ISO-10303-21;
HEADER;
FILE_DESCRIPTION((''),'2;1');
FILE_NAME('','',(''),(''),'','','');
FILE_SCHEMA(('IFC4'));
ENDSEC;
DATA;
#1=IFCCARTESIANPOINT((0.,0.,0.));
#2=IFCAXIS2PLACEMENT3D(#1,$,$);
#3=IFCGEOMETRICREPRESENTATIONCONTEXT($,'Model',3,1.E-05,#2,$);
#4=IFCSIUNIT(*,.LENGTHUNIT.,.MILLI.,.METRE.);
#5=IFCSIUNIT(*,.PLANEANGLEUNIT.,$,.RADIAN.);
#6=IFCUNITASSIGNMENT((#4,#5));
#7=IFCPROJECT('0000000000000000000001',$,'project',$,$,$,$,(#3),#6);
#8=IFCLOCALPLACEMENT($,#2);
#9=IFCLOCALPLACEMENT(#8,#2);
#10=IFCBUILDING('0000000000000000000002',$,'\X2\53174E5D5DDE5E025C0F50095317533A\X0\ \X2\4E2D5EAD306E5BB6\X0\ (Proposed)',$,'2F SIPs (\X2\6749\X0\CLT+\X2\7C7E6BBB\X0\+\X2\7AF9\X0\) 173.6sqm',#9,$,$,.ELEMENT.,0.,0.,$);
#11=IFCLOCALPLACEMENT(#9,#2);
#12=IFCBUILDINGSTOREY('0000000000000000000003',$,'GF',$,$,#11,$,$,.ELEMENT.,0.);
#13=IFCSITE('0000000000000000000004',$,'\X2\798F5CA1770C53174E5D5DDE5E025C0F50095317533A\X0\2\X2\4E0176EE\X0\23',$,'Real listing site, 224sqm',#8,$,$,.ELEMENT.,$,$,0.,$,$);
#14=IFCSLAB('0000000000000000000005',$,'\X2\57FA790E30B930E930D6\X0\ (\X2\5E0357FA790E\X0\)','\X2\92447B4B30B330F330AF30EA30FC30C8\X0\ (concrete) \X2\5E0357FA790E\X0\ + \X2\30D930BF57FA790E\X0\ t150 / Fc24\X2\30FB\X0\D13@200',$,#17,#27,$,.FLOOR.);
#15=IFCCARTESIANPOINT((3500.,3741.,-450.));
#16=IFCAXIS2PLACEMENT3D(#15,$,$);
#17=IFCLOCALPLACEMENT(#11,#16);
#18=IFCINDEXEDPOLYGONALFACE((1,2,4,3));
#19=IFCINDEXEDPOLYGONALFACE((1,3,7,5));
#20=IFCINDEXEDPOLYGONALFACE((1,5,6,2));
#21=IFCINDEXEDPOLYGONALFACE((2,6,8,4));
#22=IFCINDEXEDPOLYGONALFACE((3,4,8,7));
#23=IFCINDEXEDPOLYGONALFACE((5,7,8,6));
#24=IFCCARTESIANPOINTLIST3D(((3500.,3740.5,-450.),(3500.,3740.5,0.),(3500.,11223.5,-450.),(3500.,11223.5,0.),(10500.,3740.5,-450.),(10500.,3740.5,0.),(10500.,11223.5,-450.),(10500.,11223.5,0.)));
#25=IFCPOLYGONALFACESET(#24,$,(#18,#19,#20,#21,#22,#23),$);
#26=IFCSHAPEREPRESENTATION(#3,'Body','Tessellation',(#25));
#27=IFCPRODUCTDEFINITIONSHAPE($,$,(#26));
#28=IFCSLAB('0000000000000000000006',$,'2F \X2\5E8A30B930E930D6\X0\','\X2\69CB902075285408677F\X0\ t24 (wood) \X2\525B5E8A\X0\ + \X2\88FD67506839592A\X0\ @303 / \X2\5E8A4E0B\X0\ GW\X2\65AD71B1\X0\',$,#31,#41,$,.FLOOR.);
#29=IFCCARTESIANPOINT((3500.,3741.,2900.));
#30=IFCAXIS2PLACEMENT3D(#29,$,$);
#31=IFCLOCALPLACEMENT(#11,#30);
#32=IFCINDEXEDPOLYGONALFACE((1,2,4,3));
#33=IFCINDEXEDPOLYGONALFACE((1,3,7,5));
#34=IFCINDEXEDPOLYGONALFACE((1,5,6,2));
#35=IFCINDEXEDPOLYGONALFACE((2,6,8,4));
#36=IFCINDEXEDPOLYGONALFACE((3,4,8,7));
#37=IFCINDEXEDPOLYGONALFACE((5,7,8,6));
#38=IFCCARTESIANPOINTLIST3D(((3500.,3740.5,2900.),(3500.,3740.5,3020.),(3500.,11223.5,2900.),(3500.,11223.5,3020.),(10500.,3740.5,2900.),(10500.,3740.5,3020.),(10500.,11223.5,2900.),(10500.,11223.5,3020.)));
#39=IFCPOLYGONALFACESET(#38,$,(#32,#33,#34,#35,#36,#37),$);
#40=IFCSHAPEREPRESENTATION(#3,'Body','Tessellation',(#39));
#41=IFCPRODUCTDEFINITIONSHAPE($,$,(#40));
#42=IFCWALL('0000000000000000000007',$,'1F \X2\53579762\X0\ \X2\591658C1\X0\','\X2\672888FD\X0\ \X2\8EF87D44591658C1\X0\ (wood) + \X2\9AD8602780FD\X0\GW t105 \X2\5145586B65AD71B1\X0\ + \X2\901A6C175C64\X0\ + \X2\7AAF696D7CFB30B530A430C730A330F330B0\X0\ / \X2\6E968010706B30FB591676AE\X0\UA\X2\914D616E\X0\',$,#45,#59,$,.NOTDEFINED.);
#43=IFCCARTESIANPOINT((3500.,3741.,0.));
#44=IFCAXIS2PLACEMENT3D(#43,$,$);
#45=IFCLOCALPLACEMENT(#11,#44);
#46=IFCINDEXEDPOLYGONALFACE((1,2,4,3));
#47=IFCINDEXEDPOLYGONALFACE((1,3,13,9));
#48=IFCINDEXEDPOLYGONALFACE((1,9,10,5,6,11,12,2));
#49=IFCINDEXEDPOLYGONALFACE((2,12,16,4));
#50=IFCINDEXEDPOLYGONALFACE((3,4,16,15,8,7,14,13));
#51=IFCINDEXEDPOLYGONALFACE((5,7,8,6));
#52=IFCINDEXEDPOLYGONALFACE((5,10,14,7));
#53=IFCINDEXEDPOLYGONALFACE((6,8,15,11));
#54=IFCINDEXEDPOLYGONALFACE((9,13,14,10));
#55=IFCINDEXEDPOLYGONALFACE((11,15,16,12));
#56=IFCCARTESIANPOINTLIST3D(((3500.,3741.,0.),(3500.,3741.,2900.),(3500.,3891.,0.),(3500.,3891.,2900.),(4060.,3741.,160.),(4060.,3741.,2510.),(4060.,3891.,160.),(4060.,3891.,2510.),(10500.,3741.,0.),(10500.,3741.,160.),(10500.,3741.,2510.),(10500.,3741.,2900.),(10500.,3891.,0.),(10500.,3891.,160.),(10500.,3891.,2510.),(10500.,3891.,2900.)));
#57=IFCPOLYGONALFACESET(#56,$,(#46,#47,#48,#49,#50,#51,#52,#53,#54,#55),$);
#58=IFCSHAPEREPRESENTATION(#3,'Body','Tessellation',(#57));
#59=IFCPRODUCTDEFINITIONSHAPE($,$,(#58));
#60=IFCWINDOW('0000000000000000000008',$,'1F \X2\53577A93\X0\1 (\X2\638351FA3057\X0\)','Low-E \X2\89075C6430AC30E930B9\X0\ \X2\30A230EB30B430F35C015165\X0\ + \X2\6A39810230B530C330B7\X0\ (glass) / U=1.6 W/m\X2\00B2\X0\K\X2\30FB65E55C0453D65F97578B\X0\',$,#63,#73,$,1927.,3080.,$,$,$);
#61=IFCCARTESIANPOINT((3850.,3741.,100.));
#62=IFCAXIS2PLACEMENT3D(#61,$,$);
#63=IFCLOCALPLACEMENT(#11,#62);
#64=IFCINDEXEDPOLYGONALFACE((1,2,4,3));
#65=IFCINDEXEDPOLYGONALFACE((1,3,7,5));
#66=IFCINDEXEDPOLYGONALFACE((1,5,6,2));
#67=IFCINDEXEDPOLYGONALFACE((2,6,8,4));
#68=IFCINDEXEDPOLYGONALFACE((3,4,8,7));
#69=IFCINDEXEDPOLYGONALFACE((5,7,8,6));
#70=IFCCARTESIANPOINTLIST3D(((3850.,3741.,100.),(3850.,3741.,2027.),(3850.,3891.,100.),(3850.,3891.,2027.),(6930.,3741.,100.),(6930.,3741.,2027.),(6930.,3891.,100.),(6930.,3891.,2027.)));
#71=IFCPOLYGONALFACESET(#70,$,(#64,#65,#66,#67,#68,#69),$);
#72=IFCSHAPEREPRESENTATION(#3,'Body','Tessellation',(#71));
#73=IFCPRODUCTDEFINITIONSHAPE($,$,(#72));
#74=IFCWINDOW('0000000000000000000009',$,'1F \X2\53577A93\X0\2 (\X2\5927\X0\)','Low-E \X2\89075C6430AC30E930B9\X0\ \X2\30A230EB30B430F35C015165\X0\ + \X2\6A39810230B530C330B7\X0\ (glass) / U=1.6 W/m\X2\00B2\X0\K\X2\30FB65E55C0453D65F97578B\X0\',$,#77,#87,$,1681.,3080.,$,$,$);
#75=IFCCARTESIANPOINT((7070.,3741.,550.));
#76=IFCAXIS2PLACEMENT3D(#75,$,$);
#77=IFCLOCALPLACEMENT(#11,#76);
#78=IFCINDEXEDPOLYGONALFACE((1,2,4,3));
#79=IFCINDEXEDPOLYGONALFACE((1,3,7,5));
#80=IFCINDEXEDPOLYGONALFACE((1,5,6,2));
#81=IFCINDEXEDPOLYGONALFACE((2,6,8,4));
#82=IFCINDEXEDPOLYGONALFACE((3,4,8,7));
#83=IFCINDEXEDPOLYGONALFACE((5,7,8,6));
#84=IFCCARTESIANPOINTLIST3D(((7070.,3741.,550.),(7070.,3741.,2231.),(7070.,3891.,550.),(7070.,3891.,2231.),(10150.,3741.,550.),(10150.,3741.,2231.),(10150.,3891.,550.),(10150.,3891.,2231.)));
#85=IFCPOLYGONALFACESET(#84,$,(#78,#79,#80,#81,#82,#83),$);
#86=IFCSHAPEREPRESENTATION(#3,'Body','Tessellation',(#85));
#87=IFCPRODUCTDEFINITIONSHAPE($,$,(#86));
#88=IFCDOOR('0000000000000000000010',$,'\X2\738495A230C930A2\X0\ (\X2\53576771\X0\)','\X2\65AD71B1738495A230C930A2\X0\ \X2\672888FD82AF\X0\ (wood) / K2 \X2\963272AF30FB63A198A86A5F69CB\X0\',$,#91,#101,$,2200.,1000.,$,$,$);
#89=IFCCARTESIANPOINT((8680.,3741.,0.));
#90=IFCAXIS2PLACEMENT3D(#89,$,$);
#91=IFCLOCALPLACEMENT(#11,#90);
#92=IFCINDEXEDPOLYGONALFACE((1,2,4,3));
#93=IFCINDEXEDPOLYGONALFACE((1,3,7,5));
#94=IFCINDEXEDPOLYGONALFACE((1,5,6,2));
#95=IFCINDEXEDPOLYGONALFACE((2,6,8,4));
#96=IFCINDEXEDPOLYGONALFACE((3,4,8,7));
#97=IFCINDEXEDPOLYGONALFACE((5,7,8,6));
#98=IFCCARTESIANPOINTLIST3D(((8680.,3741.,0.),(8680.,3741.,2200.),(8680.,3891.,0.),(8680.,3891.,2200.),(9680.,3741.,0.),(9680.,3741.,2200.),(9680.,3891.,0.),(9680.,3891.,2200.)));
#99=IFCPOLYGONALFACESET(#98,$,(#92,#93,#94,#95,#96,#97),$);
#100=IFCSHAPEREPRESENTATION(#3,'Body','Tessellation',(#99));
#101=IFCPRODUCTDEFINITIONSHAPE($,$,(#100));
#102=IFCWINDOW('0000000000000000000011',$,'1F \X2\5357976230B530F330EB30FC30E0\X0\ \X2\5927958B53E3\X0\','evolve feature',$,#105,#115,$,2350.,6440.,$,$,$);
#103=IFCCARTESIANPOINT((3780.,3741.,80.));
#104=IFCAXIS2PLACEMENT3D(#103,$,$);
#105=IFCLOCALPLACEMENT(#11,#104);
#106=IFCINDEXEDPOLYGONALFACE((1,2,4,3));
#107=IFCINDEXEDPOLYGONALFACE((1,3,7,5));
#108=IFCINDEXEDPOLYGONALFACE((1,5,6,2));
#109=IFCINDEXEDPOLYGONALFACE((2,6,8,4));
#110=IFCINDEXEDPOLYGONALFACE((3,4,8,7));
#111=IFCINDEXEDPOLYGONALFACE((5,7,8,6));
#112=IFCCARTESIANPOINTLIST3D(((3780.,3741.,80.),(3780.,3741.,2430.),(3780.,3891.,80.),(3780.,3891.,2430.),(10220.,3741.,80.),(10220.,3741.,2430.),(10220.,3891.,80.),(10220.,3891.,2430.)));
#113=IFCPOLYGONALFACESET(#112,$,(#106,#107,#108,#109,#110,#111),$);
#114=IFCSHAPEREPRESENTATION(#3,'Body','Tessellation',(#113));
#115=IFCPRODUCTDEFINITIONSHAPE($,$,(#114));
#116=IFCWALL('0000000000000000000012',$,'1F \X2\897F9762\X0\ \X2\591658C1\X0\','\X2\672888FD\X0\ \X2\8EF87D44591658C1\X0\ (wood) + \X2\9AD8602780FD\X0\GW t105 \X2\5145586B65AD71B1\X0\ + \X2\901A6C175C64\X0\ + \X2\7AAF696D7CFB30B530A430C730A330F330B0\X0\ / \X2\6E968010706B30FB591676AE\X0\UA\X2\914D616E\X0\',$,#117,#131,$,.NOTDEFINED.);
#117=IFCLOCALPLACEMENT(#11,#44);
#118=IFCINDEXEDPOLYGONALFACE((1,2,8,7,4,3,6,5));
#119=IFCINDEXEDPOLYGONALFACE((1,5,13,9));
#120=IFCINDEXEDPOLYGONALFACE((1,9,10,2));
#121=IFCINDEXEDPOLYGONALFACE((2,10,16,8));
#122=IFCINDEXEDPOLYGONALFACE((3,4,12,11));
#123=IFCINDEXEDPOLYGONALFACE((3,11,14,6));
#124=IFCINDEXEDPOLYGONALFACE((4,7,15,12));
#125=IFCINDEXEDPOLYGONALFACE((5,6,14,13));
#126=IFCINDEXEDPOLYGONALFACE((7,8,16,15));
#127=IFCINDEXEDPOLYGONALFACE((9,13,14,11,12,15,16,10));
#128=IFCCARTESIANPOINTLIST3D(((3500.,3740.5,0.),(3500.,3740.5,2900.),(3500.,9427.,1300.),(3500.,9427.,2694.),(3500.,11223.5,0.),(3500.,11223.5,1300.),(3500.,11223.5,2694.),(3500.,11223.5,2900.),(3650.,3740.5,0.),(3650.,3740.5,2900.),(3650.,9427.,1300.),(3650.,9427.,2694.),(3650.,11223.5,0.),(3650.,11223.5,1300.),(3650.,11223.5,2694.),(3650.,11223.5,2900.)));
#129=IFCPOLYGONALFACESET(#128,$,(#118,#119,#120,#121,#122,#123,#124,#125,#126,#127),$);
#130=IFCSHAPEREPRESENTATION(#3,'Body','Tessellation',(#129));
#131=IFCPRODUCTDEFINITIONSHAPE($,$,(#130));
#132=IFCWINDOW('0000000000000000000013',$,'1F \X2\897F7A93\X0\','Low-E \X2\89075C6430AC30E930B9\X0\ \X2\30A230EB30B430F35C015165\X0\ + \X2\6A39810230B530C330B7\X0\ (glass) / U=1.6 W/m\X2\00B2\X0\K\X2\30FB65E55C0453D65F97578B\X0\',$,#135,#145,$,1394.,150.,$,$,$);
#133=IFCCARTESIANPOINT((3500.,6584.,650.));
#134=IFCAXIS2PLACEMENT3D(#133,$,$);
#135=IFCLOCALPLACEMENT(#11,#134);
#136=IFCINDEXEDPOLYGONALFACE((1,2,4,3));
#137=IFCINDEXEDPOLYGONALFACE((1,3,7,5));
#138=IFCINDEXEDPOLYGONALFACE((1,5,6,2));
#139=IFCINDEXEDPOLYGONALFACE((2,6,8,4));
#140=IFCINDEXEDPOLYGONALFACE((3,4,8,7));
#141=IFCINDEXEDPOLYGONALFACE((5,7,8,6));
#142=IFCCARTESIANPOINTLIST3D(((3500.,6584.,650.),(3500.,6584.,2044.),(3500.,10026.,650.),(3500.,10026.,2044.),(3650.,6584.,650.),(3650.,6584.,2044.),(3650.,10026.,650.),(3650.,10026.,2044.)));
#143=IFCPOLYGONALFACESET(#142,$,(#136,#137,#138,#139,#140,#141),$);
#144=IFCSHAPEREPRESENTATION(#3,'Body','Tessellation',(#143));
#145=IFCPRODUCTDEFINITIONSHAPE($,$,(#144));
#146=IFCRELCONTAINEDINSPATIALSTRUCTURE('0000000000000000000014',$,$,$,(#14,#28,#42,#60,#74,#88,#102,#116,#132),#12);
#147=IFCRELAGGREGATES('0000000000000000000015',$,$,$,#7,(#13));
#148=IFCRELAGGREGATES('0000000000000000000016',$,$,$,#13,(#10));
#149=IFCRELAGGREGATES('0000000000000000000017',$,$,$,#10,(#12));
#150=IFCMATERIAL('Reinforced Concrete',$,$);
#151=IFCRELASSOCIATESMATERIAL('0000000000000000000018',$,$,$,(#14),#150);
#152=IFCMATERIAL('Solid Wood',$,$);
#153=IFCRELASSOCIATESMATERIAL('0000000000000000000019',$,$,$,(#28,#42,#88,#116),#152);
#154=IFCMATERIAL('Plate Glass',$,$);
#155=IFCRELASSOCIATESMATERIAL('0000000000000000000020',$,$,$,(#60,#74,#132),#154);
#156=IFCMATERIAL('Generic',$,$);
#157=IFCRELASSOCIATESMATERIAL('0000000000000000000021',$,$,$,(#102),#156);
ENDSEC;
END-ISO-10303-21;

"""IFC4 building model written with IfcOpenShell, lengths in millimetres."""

from ifc_helpers import new_model, si_unit, frame, frame_2d, origin, place, context, project, spatial, rectangle, extrude, material, element, fill, save


model = new_model("IFC4")

# Units and contexts
model_context = context("Model", 3, precision=1e-05, world=origin())
ifc_project = project(units=[si_unit("LENGTHUNIT", "METRE", prefix="MILLI"), si_unit("PLANEANGLEUNIT", "RADIAN")], contexts=[model_context])

# Site, building, storey
site_placement = place(None, origin())
site = spatial("IfcSite", under=ifc_project, at=site_placement, Name="福岡県北九州市小倉北区2丁目23", ObjectType="Real listing site, 224sqm", CompositionType="ELEMENT", RefElevation=0.0)
building_placement = place(site_placement, origin())
building = spatial("IfcBuilding", under=site, at=building_placement, Name="北九州市小倉北区 中庭の家 (Proposed)", ObjectType="2F SIPs (杉CLT+籾殻+竹) 173.6sqm", CompositionType="ELEMENT", ElevationOfRefHeight=0.0, ElevationOfTerrain=0.0)
storey_placement = place(building_placement, origin())
storey = spatial("IfcBuildingStorey", under=building, at=storey_placement, Name="GF", CompositionType="ELEMENT", Elevation=0.0)

# Slabs
ifc_material_1 = material(Name="Reinforced Concrete")
slab_1_placement = place(storey_placement, frame((3500.0, 3741.0, -450.0)))
element("IfcSlab", 1, at=slab_1_placement, inside=storey, material=ifc_material_1, Name="基礎スラブ (布基礎)", Description="鉄筋コンクリート (concrete) 布基礎 + ベタ基礎 t150 / Fc24・D13@200", PredefinedType="FLOOR", context=model_context, shape_type="SweptSolid", body=[
    extrude(rectangle(XDim=7000.0, YDim=7483.0, at=frame_2d((3500.0, 3741.0))), frame((3500.0, 3741.0, -450.0)), (0.0, 0.0, 1.0), 450.0),
])
ifc_material_2 = material(Name="Solid Wood")
slab_2_placement = place(storey_placement, frame((3500.0, 3741.0, 2900.0)))
element("IfcSlab", 2, at=slab_2_placement, inside=storey, material=ifc_material_2, Name="2F 床スラブ", Description="構造用合板 t24 (wood) 剛床 + 製材根太 @303 / 床下 GW断熱", PredefinedType="FLOOR", context=model_context, shape_type="SweptSolid", body=[
    extrude(rectangle(XDim=7000.0, YDim=7483.0, at=frame_2d((3500.0, 3741.0))), frame((3500.0, 3741.0, 2900.0)), (0.0, 0.0, 1.0), 120.0),
])
ifc_material_3 = material(Name="Generic")

# Wall, openings, windows, door
wall_1_placement = place(storey_placement, frame((3500.0, 3741.0, 0.0)))
wall_1 = element("IfcWall", 3, at=wall_1_placement, inside=storey, material=ifc_material_2, Name="1F 南面 外壁", Description="木製 軸組外壁 (wood) + 高性能GW t105 充填断熱 + 通気層 + 窯業系サイディング / 準耐火・外皮UA配慮", PredefinedType="NOTDEFINED", context=model_context, shape_type="SweptSolid", body=[
    extrude(rectangle(XDim=7000.0, YDim=150.0, at=frame_2d((3500.0, 75.0))), frame((3500.0, 3741.0, 0.0)), (0.0, 0.0, 1.0), 2900.0),
])
opening_1_placement = place(storey_placement, frame((3850.0, 3741.0, 100.0)))
opening_1 = element("IfcOpeningElement", 4, at=opening_1_placement, cuts=wall_1, PredefinedType="NOTDEFINED", context=model_context, shape_type="SweptSolid", body=[
    extrude(rectangle(XDim=3080.0, YDim=150.0, at=frame_2d((1540.0, 75.0))), frame((3850.0, 3741.0, 100.0)), (0.0, 0.0, 1.0), 1927.0),
])
opening_2_placement = place(storey_placement, frame((7070.0, 3741.0, 550.0)))
opening_2 = element("IfcOpeningElement", 5, at=opening_2_placement, cuts=wall_1, PredefinedType="NOTDEFINED", context=model_context, shape_type="SweptSolid", body=[
    extrude(rectangle(XDim=3080.0, YDim=150.0, at=frame_2d((1540.0, 75.0))), frame((7070.0, 3741.0, 550.0)), (0.0, 0.0, 1.0), 1681.0),
])
opening_3_placement = place(storey_placement, frame((8680.0, 3741.0, 0.0)))
opening_3 = element("IfcOpeningElement", 6, at=opening_3_placement, cuts=wall_1, PredefinedType="NOTDEFINED", context=model_context, shape_type="SweptSolid", body=[
    extrude(rectangle(XDim=1000.0, YDim=150.0, at=frame_2d((500.0, 75.0))), frame((8680.0, 3741.0, 0.0)), (0.0, 0.0, 1.0), 2200.0),
])
opening_4_placement = place(storey_placement, frame((3780.0, 3741.0, 80.0)))
opening_4 = element("IfcOpeningElement", 7, at=opening_4_placement, cuts=wall_1, PredefinedType="NOTDEFINED", context=model_context, shape_type="SweptSolid", body=[
    extrude(rectangle(XDim=6440.0, YDim=150.0, at=frame_2d((3220.0, 75.0))), frame((3780.0, 3741.0, 80.0)), (0.0, 0.0, 1.0), 2350.0),
])
ifc_material_4 = material(Name="Plate Glass")
window_1_placement = place(storey_placement, frame((3850.0, 3741.0, 100.0)))
window_1 = element("IfcWindow", 8, at=window_1_placement, inside=storey, material=ifc_material_4, Name="1F 南窓1 (掃出し)", Description="Low-E 複層ガラス アルゴン封入 + 樹脂サッシ (glass) / U=1.6 W/m²K・日射取得型", OverallHeight=1927.0, OverallWidth=3080.0, context=model_context, shape_type="SweptSolid", body=[
    extrude(rectangle(XDim=3080.0, YDim=150.0, at=frame_2d((1540.0, 75.0))), frame((3850.0, 3741.0, 100.0)), (0.0, 0.0, 1.0), 1927.0),
])
fill(opening_1, window_1)
window_2_placement = place(storey_placement, frame((7070.0, 3741.0, 550.0)))
window_2 = element("IfcWindow", 9, at=window_2_placement, inside=storey, material=ifc_material_4, Name="1F 南窓2 (大)", Description="Low-E 複層ガラス アルゴン封入 + 樹脂サッシ (glass) / U=1.6 W/m²K・日射取得型", OverallHeight=1681.0, OverallWidth=3080.0, context=model_context, shape_type="SweptSolid", body=[
    extrude(rectangle(XDim=3080.0, YDim=150.0, at=frame_2d((1540.0, 75.0))), frame((7070.0, 3741.0, 550.0)), (0.0, 0.0, 1.0), 1681.0),
])
fill(opening_2, window_2)
door_placement = place(storey_placement, frame((8680.0, 3741.0, 0.0)))
door = element("IfcDoor", 10, at=door_placement, inside=storey, material=ifc_material_2, Name="玄関ドア (南東)", Description="断熱玄関ドア 木製芯 (wood) / K2 防犯・採風機構", OverallHeight=2200.0, OverallWidth=1000.0, context=model_context, shape_type="SweptSolid", body=[
    extrude(rectangle(XDim=1000.0, YDim=150.0, at=frame_2d((500.0, 75.0))), frame((8680.0, 3741.0, 0.0)), (0.0, 0.0, 1.0), 2200.0),
])
fill(opening_3, door)
window_3_placement = place(storey_placement, frame((3780.0, 3741.0, 80.0)))
window_3 = element("IfcWindow", 11, at=window_3_placement, inside=storey, material=ifc_material_3, Name="1F 南面サンルーム 大開口", Description="evolve feature", OverallHeight=2350.0, OverallWidth=6440.0, context=model_context, shape_type="SweptSolid", body=[
    extrude(rectangle(XDim=6440.0, YDim=150.0, at=frame_2d((3220.0, 75.0))), frame((3780.0, 3741.0, 80.0)), (0.0, 0.0, 1.0), 2350.0),
])
fill(opening_4, window_3)

# Wall, opening, window
wall_2_placement = place(storey_placement, frame((3500.0, 3741.0, 0.0)))
wall_2 = element("IfcWall", 12, at=wall_2_placement, inside=storey, material=ifc_material_2, Name="1F 西面 外壁", Description="木製 軸組外壁 (wood) + 高性能GW t105 充填断熱 + 通気層 + 窯業系サイディング / 準耐火・外皮UA配慮", PredefinedType="NOTDEFINED", context=model_context, shape_type="SweptSolid", body=[
    extrude(rectangle(XDim=150.0, YDim=7483.0, at=frame_2d((75.0, 3741.0))), frame((3500.0, 3741.0, 0.0)), (0.0, 0.0, 1.0), 2900.0),
])
opening_5_placement = place(storey_placement, frame((3500.0, 6584.0, 650.0)))
opening_5 = element("IfcOpeningElement", 13, at=opening_5_placement, cuts=wall_2, PredefinedType="NOTDEFINED", context=model_context, shape_type="SweptSolid", body=[
    extrude(rectangle(XDim=150.0, YDim=3442.0, at=frame_2d((75.0, 1721.0))), frame((3500.0, 6584.0, 650.0)), (0.0, 0.0, 1.0), 1394.0),
])
window_4_placement = place(storey_placement, frame((3500.0, 6584.0, 650.0)))
window_4 = element("IfcWindow", 14, at=window_4_placement, inside=storey, material=ifc_material_4, Name="1F 西窓", Description="Low-E 複層ガラス アルゴン封入 + 樹脂サッシ (glass) / U=1.6 W/m²K・日射取得型", OverallHeight=1394.0, OverallWidth=150.0, context=model_context, shape_type="SweptSolid", body=[
    extrude(rectangle(XDim=150.0, YDim=3442.0, at=frame_2d((75.0, 1721.0))), frame((3500.0, 6584.0, 650.0)), (0.0, 0.0, 1.0), 1394.0),
])
fill(opening_5, window_4)

save(model, "model.ifc")
